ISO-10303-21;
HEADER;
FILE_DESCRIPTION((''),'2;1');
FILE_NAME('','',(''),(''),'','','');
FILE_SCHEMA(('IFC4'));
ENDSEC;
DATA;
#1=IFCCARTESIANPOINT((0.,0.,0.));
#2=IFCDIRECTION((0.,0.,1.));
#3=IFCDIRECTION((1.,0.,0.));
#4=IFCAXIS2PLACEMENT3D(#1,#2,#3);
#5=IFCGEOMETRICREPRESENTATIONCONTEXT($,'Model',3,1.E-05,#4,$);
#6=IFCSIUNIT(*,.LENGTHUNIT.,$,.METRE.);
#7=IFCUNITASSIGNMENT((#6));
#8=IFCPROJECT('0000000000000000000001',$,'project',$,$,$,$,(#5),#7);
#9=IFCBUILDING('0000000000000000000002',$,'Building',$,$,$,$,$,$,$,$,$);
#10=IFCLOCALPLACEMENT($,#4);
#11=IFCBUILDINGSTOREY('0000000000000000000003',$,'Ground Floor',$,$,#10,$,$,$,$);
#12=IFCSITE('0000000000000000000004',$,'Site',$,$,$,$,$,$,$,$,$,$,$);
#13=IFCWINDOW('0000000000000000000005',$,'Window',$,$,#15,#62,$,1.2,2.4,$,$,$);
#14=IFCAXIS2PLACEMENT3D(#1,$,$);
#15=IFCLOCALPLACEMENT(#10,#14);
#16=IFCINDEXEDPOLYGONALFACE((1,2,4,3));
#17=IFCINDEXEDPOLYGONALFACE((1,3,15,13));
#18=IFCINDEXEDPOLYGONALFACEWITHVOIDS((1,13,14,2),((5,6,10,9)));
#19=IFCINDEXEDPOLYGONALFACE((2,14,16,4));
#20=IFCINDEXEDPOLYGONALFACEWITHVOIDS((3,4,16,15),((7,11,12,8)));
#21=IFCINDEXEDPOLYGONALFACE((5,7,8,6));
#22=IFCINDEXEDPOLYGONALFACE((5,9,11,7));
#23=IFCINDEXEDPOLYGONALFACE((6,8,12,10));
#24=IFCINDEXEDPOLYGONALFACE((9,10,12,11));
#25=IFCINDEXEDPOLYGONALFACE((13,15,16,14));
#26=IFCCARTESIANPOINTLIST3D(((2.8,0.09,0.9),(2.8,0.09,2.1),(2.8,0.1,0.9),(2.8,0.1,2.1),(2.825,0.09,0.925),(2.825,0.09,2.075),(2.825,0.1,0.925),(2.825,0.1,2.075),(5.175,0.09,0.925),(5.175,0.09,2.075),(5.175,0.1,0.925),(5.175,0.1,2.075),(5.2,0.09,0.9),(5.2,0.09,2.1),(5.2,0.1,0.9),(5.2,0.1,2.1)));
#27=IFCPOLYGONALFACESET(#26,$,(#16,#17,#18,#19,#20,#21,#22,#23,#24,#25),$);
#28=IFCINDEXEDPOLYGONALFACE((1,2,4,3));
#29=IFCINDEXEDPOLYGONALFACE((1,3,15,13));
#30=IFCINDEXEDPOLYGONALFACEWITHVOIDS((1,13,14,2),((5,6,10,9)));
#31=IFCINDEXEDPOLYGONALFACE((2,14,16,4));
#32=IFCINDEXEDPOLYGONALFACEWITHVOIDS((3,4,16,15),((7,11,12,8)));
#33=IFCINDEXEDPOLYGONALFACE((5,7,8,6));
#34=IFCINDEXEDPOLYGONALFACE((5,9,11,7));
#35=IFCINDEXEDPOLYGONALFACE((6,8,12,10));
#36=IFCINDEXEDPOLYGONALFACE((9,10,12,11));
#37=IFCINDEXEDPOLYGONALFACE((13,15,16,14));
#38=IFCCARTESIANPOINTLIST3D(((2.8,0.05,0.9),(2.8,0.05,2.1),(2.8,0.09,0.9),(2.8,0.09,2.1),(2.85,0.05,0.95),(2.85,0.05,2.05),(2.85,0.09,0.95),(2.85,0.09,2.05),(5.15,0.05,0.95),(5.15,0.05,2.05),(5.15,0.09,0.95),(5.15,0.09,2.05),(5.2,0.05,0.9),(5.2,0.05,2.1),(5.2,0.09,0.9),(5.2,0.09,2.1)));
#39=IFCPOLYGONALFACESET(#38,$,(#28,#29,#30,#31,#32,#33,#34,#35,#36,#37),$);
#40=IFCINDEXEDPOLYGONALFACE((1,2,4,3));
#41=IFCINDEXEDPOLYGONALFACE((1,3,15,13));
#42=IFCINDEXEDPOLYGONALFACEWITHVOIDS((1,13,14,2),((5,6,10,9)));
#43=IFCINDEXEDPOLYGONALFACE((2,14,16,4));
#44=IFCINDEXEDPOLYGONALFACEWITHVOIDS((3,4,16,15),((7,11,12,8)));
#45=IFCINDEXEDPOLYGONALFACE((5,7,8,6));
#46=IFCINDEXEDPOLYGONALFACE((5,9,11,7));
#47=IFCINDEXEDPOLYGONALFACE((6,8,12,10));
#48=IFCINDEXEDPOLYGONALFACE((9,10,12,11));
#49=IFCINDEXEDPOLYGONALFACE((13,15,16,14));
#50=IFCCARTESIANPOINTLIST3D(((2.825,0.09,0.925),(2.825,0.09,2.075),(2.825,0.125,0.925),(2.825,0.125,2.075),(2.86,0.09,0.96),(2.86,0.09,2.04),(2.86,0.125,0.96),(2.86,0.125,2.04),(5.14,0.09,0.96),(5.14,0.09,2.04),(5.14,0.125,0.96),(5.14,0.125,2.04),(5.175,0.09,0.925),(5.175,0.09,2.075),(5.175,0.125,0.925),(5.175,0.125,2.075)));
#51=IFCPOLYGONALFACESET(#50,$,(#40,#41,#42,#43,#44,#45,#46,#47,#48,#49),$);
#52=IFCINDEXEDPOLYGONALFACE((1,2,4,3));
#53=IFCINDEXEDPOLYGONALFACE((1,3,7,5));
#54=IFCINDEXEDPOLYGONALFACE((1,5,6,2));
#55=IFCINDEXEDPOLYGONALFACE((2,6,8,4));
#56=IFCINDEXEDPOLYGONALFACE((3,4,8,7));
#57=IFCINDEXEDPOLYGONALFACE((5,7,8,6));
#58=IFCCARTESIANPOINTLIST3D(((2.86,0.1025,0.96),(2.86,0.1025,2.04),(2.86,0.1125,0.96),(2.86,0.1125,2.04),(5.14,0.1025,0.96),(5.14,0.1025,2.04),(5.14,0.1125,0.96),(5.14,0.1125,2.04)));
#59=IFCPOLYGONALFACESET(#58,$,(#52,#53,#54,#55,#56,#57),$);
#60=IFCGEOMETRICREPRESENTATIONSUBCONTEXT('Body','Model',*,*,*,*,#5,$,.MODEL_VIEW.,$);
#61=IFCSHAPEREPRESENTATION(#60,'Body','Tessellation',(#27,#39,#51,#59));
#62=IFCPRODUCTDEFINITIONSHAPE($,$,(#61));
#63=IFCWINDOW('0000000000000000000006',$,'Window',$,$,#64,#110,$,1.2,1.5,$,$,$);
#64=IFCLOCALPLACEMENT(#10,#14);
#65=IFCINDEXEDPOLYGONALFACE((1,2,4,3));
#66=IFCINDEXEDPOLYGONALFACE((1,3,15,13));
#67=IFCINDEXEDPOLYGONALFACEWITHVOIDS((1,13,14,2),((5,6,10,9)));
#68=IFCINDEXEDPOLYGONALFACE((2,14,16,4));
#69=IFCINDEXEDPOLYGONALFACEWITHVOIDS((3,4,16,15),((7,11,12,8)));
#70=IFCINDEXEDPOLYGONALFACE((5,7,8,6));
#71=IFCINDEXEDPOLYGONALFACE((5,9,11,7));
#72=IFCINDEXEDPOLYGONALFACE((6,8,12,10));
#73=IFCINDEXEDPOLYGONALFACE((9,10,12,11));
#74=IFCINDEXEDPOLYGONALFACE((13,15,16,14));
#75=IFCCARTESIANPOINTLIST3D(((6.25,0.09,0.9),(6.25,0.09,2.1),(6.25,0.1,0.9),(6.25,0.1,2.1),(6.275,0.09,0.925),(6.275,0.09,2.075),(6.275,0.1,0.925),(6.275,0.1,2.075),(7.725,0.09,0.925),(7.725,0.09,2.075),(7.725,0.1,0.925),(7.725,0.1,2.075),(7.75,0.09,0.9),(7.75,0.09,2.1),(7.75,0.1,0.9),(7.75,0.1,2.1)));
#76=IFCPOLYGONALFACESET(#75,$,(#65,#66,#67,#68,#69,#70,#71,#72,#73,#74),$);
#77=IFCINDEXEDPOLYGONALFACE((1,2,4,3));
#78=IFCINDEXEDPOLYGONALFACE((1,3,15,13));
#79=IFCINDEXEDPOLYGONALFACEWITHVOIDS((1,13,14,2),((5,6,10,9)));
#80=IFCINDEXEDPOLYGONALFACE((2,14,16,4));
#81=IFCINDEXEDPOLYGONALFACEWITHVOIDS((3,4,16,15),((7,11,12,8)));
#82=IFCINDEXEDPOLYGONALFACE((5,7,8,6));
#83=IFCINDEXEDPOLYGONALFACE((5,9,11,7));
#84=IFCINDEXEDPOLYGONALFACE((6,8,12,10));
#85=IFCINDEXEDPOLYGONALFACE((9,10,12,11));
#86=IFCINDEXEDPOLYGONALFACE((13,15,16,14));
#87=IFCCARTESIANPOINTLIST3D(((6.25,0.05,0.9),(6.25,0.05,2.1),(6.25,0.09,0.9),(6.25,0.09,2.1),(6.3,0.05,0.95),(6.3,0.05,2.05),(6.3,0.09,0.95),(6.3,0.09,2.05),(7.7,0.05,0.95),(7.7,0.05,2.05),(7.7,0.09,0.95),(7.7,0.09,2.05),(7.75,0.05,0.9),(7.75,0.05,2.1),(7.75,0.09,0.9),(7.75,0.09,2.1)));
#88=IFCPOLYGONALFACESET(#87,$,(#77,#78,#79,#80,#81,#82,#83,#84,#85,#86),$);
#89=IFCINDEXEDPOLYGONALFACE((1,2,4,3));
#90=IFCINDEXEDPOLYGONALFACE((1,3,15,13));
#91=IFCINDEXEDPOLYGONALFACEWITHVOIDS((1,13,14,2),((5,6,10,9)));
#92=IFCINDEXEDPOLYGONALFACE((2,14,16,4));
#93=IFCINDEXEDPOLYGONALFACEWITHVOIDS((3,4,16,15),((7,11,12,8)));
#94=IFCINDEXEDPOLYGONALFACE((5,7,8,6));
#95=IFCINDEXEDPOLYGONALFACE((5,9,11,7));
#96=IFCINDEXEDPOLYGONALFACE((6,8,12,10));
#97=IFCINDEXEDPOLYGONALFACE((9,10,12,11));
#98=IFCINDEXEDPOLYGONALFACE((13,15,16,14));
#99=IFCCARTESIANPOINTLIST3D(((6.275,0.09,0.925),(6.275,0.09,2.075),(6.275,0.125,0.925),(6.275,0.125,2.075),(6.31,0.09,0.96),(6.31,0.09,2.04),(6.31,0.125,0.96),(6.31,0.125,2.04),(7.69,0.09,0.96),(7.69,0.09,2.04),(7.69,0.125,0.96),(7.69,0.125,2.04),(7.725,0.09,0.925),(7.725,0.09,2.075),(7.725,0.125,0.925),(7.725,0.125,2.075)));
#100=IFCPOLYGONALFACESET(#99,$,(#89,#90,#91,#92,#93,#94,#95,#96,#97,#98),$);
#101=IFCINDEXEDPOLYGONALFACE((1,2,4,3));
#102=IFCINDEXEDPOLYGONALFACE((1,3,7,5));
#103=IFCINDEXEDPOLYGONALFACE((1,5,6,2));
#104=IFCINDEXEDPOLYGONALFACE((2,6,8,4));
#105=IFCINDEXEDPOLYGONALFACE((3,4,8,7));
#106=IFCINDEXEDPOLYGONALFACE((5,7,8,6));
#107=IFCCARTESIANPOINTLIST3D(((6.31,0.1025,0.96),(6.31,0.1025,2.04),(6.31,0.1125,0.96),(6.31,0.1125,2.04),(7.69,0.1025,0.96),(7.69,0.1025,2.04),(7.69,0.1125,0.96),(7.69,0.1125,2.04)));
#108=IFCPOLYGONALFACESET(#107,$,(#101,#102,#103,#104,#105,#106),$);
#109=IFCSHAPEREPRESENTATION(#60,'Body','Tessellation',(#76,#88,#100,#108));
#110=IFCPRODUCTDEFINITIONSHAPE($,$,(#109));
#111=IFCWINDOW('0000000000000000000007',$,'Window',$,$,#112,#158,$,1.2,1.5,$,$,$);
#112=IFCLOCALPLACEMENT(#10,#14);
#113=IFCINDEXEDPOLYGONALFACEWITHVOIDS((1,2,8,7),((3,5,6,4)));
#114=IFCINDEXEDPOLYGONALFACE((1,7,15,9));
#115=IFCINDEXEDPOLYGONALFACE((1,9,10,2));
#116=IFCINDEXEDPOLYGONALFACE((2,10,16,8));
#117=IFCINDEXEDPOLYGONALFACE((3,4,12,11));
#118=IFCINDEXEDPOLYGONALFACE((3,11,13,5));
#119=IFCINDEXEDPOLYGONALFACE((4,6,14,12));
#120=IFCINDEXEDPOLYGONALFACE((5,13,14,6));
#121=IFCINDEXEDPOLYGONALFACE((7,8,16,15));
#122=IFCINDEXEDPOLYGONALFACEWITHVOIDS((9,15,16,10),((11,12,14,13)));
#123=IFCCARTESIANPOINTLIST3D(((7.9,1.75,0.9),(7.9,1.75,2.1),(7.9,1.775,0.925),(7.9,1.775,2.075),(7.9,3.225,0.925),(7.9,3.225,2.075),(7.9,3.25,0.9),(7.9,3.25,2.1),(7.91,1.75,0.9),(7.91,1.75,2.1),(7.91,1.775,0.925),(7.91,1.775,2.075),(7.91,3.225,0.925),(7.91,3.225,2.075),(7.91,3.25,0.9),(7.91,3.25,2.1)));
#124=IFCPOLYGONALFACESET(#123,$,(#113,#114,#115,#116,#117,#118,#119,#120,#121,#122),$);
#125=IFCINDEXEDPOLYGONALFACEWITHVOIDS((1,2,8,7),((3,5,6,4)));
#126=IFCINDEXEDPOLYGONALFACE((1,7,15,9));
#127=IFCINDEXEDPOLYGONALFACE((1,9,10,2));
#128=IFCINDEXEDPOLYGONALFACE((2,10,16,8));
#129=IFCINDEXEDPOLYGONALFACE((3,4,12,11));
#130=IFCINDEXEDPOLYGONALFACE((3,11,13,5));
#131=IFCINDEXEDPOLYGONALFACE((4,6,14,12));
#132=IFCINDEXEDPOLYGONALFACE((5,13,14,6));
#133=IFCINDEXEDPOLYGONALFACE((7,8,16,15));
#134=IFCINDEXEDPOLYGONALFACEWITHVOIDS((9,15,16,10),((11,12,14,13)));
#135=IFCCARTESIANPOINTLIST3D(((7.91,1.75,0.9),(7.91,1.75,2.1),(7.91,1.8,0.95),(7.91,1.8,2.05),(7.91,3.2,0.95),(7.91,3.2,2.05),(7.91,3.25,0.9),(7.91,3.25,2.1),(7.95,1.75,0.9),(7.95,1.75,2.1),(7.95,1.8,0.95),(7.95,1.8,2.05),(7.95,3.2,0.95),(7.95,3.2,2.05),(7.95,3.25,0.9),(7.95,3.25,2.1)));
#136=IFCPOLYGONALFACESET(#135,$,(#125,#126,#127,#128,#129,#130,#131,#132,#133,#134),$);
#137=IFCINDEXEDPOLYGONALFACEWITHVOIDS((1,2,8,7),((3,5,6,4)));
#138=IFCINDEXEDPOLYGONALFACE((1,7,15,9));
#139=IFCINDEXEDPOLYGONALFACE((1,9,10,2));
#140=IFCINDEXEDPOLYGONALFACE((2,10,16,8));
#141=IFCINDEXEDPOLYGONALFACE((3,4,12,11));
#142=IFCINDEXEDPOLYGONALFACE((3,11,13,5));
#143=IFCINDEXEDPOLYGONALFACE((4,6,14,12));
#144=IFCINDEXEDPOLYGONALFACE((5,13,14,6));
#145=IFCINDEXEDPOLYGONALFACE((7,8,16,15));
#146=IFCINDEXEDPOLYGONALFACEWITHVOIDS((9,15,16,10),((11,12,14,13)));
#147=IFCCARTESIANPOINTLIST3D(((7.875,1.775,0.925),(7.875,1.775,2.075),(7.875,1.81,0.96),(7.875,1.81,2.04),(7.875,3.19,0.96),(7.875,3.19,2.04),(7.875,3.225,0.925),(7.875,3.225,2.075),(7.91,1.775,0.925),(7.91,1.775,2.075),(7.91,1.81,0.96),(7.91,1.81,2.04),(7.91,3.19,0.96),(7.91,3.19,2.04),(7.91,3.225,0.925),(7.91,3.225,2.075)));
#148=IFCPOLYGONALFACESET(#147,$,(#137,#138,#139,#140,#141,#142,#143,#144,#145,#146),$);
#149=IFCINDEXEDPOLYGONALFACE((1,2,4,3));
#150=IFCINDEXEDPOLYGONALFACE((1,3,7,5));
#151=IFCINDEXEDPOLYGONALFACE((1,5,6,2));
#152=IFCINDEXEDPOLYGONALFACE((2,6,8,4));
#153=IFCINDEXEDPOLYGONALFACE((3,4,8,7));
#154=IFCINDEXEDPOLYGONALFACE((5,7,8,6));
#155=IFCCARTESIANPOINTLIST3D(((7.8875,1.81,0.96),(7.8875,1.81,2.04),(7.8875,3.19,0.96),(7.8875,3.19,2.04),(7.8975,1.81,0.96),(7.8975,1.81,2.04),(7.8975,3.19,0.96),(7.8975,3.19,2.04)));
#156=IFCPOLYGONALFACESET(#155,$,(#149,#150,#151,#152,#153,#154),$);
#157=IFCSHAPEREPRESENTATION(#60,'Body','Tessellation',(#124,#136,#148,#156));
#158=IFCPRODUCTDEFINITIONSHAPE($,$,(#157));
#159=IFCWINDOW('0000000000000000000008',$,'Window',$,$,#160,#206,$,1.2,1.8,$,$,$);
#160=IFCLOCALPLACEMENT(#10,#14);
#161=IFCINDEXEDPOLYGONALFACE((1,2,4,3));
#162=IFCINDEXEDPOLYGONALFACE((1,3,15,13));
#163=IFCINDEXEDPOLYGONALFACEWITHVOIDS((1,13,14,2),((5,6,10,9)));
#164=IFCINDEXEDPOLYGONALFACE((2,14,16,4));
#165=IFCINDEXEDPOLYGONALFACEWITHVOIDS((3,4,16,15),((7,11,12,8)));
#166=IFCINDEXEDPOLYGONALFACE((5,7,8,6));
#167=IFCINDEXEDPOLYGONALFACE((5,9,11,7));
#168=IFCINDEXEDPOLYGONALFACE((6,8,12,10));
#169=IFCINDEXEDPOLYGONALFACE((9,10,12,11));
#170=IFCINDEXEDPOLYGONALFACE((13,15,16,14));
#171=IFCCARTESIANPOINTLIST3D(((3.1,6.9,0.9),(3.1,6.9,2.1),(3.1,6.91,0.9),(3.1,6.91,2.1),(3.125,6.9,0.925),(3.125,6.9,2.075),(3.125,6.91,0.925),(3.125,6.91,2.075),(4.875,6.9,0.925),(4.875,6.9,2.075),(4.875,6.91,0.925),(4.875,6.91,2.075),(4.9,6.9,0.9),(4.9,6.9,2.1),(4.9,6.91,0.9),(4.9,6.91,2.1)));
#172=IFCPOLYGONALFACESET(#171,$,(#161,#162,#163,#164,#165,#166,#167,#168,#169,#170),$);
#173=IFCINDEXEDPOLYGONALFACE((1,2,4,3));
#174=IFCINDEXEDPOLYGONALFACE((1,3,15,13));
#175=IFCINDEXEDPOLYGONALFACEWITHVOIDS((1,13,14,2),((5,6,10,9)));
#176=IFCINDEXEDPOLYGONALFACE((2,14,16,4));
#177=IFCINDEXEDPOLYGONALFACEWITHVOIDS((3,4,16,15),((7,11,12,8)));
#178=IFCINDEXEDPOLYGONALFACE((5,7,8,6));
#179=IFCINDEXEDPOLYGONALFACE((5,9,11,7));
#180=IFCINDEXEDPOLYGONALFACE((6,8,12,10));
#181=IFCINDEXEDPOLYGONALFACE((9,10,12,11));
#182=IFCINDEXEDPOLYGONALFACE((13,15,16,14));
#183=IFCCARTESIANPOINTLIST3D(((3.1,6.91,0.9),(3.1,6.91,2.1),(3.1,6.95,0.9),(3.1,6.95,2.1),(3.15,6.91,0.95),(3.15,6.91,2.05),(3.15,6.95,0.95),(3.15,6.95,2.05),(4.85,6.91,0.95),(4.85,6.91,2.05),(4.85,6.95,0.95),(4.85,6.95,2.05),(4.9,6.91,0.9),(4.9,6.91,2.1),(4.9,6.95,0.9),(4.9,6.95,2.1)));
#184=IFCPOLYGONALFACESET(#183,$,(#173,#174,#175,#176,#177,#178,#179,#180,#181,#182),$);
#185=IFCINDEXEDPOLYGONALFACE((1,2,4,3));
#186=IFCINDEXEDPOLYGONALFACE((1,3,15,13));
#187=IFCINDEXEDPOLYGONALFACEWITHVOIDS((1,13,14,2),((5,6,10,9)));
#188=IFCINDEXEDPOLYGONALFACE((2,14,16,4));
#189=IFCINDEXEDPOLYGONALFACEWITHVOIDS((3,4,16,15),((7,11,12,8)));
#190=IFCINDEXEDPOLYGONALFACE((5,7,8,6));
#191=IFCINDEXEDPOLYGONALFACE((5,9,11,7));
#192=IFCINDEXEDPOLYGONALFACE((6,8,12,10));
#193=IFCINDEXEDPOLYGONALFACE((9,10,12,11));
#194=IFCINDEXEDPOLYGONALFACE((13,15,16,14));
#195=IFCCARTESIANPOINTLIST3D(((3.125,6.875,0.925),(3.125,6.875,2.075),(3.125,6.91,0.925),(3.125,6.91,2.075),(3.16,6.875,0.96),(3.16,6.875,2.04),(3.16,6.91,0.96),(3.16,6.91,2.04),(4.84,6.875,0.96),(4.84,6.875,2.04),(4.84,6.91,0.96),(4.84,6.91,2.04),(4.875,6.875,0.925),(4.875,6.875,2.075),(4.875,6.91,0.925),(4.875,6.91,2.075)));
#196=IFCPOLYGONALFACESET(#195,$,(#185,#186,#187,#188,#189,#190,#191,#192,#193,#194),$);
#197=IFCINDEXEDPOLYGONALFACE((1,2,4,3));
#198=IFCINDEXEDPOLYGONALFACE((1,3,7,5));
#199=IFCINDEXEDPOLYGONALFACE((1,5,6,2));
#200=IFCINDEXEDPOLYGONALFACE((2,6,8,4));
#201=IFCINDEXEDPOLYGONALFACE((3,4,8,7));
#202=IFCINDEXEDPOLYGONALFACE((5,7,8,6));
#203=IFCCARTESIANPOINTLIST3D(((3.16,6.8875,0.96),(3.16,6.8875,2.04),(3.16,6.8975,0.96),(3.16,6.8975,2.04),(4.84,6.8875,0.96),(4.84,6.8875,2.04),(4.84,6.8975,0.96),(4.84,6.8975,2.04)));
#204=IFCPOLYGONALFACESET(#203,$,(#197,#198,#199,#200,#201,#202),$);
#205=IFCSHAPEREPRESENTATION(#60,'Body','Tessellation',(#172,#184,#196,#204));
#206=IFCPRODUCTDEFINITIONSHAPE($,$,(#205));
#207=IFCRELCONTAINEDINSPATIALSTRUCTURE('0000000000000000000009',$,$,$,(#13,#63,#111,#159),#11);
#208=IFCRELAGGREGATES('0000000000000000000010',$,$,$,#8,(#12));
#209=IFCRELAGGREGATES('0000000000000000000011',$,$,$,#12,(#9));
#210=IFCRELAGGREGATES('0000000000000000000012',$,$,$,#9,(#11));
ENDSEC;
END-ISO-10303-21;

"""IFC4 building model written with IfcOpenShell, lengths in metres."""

from ifc_helpers import new_model, si_unit, frame, origin_with_axes, place, context, subcontext, project, spatial, line, indexed_curve, outline, extrude, element, save


model = new_model("IFC4")

# Units and contexts
model_context = context("Model", 3, precision=1e-05, world=origin_with_axes())
body_context = subcontext(model_context, "Body", "Model", "MODEL_VIEW")
ifc_project = project(units=[si_unit("LENGTHUNIT", "METRE")], contexts=[model_context])

# Site, building, storey
site = spatial("IfcSite", under=ifc_project, Name="Site")
building = spatial("IfcBuilding", under=site, Name="Building")
storey_placement = place(None, origin_with_axes())
storey = spatial("IfcBuildingStorey", under=building, at=storey_placement, Name="Ground Floor")

# Windows
window_1_placement = place(storey_placement, frame((2.8, 0.0, 0.9), z_axis=(0.0, 0.0, 1.0), x_axis=(1.0, 0.0, 0.0)))
element("IfcWindow", 1, at=window_1_placement, inside=storey, Name="Window", OverallHeight=1.2, OverallWidth=2.4, context=body_context, shape_type="SweptSolid", body=[
    extrude(outline(indexed_curve([(0.0, 0.0), (2.4, 0.0), (2.4, 1.2), (0.0, 1.2)], segments=[line(1, 2, 3, 4, 1)]), holes=[indexed_curve([(0.025, 0.025), (2.375, 0.025), (2.375, 1.175), (0.025, 1.175)], segments=[line(1, 2, 3, 4, 1)])]), frame((0.0, 0.09, 0.0), z_axis=(0.0, -1.0, 0.0), x_axis=(1.0, 0.0, 0.0)), (0.0, 0.0, -1.0), 0.01),
    extrude(outline(indexed_curve([(0.0, 0.0), (2.4, 0.0), (2.4, 1.2), (0.0, 1.2)], segments=[line(1, 2, 3, 4, 1)]), holes=[indexed_curve([(0.05, 0.05), (2.35, 0.05), (2.35, 1.15), (0.05, 1.15)], segments=[line(1, 2, 3, 4, 1)])]), frame((0.0, 0.05, 0.0), z_axis=(0.0, -1.0, 0.0), x_axis=(1.0, 0.0, 0.0)), (0.0, 0.0, -1.0), 0.04),
    extrude(outline(indexed_curve([(0.0, 0.0), (2.35, 0.0), (2.35, 1.15), (0.0, 1.15)], segments=[line(1, 2, 3, 4, 1)]), holes=[indexed_curve([(0.035, 0.035), (2.315, 0.035), (2.315, 1.115), (0.035, 1.115)], segments=[line(1, 2, 3, 4, 1)])]), frame((0.025, 0.09, 0.025), z_axis=(0.0, -1.0, 0.0), x_axis=(1.0, 0.0, 0.0)), (0.0, 0.0, -1.0), 0.035),
    extrude(outline(indexed_curve([(0.035, 0.035), (2.315, 0.035), (2.315, 1.115), (0.035, 1.115)], segments=[line(1, 2, 3, 4, 1)])), frame((0.025, 0.1025, 0.025), z_axis=(0.0, -1.0, 0.0), x_axis=(1.0, 0.0, 0.0)), (0.0, 0.0, -1.0), 0.01),
])
for number, where, z_axis, x_axis, name in (
    (2, (6.25, 0.0, 0.9), (0.0, 0.0, 1.0), (1.0, 0.0, 0.0), "Window"),
    (3, (8.0, 1.75, 0.9), (0.0, 0.0, 1.0), (0.0, 1.0, 0.0), "Window"),
):
    element("IfcWindow", number, at=place(storey_placement, frame(where, z_axis=z_axis, x_axis=x_axis)), inside=storey, Name=name, OverallHeight=1.2, OverallWidth=1.5, context=body_context, shape_type="SweptSolid", body=[
        extrude(outline(indexed_curve([(0.0, 0.0), (1.5, 0.0), (1.5, 1.2), (0.0, 1.2)], segments=[line(1, 2, 3, 4, 1)]), holes=[indexed_curve([(0.025, 0.025), (1.475, 0.025), (1.475, 1.175), (0.025, 1.175)], segments=[line(1, 2, 3, 4, 1)])]), frame((0.0, 0.09, 0.0), z_axis=(0.0, -1.0, 0.0), x_axis=(1.0, 0.0, 0.0)), (0.0, 0.0, -1.0), 0.01),
        extrude(outline(indexed_curve([(0.0, 0.0), (1.5, 0.0), (1.5, 1.2), (0.0, 1.2)], segments=[line(1, 2, 3, 4, 1)]), holes=[indexed_curve([(0.05, 0.05), (1.45, 0.05), (1.45, 1.15), (0.05, 1.15)], segments=[line(1, 2, 3, 4, 1)])]), frame((0.0, 0.05, 0.0), z_axis=(0.0, -1.0, 0.0), x_axis=(1.0, 0.0, 0.0)), (0.0, 0.0, -1.0), 0.04),
        extrude(outline(indexed_curve([(0.0, 0.0), (1.45, 0.0), (1.45, 1.15), (0.0, 1.15)], segments=[line(1, 2, 3, 4, 1)]), holes=[indexed_curve([(0.035, 0.035), (1.415, 0.035), (1.415, 1.115), (0.035, 1.115)], segments=[line(1, 2, 3, 4, 1)])]), frame((0.025, 0.09, 0.025), z_axis=(0.0, -1.0, 0.0), x_axis=(1.0, 0.0, 0.0)), (0.0, 0.0, -1.0), 0.035),
        extrude(outline(indexed_curve([(0.035, 0.035), (1.415, 0.035), (1.415, 1.115), (0.035, 1.115)], segments=[line(1, 2, 3, 4, 1)])), frame((0.025, 0.1025, 0.025), z_axis=(0.0, -1.0, 0.0), x_axis=(1.0, 0.0, 0.0)), (0.0, 0.0, -1.0), 0.01),
    ])
window_2_placement = place(storey_placement, frame((4.9, 7.0, 0.9), z_axis=(0.0, 0.0, 1.0), x_axis=(-1.0, 0.0, 0.0)))
element("IfcWindow", 4, at=window_2_placement, inside=storey, Name="Window", OverallHeight=1.2, OverallWidth=1.8, context=body_context, shape_type="SweptSolid", body=[
    extrude(outline(indexed_curve([(0.0, 0.0), (1.8, 0.0), (1.8, 1.2), (0.0, 1.2)], segments=[line(1, 2, 3, 4, 1)]), holes=[indexed_curve([(0.025, 0.025), (1.775, 0.025), (1.775, 1.175), (0.025, 1.175)], segments=[line(1, 2, 3, 4, 1)])]), frame((0.0, 0.09, 0.0), z_axis=(0.0, -1.0, 0.0), x_axis=(1.0, 0.0, 0.0)), (0.0, 0.0, -1.0), 0.01),
    extrude(outline(indexed_curve([(0.0, 0.0), (1.8, 0.0), (1.8, 1.2), (0.0, 1.2)], segments=[line(1, 2, 3, 4, 1)]), holes=[indexed_curve([(0.05, 0.05), (1.75, 0.05), (1.75, 1.15), (0.05, 1.15)], segments=[line(1, 2, 3, 4, 1)])]), frame((0.0, 0.05, 0.0), z_axis=(0.0, -1.0, 0.0), x_axis=(1.0, 0.0, 0.0)), (0.0, 0.0, -1.0), 0.04),
    extrude(outline(indexed_curve([(0.0, 0.0), (1.75, 0.0), (1.75, 1.15), (0.0, 1.15)], segments=[line(1, 2, 3, 4, 1)]), holes=[indexed_curve([(0.035, 0.035), (1.715, 0.035), (1.715, 1.115), (0.035, 1.115)], segments=[line(1, 2, 3, 4, 1)])]), frame((0.025, 0.09, 0.025), z_axis=(0.0, -1.0, 0.0), x_axis=(1.0, 0.0, 0.0)), (0.0, 0.0, -1.0), 0.035),
    extrude(outline(indexed_curve([(0.035, 0.035), (1.715, 0.035), (1.715, 1.115), (0.035, 1.115)], segments=[line(1, 2, 3, 4, 1)])), frame((0.025, 0.1025, 0.025), z_axis=(0.0, -1.0, 0.0), x_axis=(1.0, 0.0, 0.0)), (0.0, 0.0, -1.0), 0.01),
])

save(model, "model.ifc")
